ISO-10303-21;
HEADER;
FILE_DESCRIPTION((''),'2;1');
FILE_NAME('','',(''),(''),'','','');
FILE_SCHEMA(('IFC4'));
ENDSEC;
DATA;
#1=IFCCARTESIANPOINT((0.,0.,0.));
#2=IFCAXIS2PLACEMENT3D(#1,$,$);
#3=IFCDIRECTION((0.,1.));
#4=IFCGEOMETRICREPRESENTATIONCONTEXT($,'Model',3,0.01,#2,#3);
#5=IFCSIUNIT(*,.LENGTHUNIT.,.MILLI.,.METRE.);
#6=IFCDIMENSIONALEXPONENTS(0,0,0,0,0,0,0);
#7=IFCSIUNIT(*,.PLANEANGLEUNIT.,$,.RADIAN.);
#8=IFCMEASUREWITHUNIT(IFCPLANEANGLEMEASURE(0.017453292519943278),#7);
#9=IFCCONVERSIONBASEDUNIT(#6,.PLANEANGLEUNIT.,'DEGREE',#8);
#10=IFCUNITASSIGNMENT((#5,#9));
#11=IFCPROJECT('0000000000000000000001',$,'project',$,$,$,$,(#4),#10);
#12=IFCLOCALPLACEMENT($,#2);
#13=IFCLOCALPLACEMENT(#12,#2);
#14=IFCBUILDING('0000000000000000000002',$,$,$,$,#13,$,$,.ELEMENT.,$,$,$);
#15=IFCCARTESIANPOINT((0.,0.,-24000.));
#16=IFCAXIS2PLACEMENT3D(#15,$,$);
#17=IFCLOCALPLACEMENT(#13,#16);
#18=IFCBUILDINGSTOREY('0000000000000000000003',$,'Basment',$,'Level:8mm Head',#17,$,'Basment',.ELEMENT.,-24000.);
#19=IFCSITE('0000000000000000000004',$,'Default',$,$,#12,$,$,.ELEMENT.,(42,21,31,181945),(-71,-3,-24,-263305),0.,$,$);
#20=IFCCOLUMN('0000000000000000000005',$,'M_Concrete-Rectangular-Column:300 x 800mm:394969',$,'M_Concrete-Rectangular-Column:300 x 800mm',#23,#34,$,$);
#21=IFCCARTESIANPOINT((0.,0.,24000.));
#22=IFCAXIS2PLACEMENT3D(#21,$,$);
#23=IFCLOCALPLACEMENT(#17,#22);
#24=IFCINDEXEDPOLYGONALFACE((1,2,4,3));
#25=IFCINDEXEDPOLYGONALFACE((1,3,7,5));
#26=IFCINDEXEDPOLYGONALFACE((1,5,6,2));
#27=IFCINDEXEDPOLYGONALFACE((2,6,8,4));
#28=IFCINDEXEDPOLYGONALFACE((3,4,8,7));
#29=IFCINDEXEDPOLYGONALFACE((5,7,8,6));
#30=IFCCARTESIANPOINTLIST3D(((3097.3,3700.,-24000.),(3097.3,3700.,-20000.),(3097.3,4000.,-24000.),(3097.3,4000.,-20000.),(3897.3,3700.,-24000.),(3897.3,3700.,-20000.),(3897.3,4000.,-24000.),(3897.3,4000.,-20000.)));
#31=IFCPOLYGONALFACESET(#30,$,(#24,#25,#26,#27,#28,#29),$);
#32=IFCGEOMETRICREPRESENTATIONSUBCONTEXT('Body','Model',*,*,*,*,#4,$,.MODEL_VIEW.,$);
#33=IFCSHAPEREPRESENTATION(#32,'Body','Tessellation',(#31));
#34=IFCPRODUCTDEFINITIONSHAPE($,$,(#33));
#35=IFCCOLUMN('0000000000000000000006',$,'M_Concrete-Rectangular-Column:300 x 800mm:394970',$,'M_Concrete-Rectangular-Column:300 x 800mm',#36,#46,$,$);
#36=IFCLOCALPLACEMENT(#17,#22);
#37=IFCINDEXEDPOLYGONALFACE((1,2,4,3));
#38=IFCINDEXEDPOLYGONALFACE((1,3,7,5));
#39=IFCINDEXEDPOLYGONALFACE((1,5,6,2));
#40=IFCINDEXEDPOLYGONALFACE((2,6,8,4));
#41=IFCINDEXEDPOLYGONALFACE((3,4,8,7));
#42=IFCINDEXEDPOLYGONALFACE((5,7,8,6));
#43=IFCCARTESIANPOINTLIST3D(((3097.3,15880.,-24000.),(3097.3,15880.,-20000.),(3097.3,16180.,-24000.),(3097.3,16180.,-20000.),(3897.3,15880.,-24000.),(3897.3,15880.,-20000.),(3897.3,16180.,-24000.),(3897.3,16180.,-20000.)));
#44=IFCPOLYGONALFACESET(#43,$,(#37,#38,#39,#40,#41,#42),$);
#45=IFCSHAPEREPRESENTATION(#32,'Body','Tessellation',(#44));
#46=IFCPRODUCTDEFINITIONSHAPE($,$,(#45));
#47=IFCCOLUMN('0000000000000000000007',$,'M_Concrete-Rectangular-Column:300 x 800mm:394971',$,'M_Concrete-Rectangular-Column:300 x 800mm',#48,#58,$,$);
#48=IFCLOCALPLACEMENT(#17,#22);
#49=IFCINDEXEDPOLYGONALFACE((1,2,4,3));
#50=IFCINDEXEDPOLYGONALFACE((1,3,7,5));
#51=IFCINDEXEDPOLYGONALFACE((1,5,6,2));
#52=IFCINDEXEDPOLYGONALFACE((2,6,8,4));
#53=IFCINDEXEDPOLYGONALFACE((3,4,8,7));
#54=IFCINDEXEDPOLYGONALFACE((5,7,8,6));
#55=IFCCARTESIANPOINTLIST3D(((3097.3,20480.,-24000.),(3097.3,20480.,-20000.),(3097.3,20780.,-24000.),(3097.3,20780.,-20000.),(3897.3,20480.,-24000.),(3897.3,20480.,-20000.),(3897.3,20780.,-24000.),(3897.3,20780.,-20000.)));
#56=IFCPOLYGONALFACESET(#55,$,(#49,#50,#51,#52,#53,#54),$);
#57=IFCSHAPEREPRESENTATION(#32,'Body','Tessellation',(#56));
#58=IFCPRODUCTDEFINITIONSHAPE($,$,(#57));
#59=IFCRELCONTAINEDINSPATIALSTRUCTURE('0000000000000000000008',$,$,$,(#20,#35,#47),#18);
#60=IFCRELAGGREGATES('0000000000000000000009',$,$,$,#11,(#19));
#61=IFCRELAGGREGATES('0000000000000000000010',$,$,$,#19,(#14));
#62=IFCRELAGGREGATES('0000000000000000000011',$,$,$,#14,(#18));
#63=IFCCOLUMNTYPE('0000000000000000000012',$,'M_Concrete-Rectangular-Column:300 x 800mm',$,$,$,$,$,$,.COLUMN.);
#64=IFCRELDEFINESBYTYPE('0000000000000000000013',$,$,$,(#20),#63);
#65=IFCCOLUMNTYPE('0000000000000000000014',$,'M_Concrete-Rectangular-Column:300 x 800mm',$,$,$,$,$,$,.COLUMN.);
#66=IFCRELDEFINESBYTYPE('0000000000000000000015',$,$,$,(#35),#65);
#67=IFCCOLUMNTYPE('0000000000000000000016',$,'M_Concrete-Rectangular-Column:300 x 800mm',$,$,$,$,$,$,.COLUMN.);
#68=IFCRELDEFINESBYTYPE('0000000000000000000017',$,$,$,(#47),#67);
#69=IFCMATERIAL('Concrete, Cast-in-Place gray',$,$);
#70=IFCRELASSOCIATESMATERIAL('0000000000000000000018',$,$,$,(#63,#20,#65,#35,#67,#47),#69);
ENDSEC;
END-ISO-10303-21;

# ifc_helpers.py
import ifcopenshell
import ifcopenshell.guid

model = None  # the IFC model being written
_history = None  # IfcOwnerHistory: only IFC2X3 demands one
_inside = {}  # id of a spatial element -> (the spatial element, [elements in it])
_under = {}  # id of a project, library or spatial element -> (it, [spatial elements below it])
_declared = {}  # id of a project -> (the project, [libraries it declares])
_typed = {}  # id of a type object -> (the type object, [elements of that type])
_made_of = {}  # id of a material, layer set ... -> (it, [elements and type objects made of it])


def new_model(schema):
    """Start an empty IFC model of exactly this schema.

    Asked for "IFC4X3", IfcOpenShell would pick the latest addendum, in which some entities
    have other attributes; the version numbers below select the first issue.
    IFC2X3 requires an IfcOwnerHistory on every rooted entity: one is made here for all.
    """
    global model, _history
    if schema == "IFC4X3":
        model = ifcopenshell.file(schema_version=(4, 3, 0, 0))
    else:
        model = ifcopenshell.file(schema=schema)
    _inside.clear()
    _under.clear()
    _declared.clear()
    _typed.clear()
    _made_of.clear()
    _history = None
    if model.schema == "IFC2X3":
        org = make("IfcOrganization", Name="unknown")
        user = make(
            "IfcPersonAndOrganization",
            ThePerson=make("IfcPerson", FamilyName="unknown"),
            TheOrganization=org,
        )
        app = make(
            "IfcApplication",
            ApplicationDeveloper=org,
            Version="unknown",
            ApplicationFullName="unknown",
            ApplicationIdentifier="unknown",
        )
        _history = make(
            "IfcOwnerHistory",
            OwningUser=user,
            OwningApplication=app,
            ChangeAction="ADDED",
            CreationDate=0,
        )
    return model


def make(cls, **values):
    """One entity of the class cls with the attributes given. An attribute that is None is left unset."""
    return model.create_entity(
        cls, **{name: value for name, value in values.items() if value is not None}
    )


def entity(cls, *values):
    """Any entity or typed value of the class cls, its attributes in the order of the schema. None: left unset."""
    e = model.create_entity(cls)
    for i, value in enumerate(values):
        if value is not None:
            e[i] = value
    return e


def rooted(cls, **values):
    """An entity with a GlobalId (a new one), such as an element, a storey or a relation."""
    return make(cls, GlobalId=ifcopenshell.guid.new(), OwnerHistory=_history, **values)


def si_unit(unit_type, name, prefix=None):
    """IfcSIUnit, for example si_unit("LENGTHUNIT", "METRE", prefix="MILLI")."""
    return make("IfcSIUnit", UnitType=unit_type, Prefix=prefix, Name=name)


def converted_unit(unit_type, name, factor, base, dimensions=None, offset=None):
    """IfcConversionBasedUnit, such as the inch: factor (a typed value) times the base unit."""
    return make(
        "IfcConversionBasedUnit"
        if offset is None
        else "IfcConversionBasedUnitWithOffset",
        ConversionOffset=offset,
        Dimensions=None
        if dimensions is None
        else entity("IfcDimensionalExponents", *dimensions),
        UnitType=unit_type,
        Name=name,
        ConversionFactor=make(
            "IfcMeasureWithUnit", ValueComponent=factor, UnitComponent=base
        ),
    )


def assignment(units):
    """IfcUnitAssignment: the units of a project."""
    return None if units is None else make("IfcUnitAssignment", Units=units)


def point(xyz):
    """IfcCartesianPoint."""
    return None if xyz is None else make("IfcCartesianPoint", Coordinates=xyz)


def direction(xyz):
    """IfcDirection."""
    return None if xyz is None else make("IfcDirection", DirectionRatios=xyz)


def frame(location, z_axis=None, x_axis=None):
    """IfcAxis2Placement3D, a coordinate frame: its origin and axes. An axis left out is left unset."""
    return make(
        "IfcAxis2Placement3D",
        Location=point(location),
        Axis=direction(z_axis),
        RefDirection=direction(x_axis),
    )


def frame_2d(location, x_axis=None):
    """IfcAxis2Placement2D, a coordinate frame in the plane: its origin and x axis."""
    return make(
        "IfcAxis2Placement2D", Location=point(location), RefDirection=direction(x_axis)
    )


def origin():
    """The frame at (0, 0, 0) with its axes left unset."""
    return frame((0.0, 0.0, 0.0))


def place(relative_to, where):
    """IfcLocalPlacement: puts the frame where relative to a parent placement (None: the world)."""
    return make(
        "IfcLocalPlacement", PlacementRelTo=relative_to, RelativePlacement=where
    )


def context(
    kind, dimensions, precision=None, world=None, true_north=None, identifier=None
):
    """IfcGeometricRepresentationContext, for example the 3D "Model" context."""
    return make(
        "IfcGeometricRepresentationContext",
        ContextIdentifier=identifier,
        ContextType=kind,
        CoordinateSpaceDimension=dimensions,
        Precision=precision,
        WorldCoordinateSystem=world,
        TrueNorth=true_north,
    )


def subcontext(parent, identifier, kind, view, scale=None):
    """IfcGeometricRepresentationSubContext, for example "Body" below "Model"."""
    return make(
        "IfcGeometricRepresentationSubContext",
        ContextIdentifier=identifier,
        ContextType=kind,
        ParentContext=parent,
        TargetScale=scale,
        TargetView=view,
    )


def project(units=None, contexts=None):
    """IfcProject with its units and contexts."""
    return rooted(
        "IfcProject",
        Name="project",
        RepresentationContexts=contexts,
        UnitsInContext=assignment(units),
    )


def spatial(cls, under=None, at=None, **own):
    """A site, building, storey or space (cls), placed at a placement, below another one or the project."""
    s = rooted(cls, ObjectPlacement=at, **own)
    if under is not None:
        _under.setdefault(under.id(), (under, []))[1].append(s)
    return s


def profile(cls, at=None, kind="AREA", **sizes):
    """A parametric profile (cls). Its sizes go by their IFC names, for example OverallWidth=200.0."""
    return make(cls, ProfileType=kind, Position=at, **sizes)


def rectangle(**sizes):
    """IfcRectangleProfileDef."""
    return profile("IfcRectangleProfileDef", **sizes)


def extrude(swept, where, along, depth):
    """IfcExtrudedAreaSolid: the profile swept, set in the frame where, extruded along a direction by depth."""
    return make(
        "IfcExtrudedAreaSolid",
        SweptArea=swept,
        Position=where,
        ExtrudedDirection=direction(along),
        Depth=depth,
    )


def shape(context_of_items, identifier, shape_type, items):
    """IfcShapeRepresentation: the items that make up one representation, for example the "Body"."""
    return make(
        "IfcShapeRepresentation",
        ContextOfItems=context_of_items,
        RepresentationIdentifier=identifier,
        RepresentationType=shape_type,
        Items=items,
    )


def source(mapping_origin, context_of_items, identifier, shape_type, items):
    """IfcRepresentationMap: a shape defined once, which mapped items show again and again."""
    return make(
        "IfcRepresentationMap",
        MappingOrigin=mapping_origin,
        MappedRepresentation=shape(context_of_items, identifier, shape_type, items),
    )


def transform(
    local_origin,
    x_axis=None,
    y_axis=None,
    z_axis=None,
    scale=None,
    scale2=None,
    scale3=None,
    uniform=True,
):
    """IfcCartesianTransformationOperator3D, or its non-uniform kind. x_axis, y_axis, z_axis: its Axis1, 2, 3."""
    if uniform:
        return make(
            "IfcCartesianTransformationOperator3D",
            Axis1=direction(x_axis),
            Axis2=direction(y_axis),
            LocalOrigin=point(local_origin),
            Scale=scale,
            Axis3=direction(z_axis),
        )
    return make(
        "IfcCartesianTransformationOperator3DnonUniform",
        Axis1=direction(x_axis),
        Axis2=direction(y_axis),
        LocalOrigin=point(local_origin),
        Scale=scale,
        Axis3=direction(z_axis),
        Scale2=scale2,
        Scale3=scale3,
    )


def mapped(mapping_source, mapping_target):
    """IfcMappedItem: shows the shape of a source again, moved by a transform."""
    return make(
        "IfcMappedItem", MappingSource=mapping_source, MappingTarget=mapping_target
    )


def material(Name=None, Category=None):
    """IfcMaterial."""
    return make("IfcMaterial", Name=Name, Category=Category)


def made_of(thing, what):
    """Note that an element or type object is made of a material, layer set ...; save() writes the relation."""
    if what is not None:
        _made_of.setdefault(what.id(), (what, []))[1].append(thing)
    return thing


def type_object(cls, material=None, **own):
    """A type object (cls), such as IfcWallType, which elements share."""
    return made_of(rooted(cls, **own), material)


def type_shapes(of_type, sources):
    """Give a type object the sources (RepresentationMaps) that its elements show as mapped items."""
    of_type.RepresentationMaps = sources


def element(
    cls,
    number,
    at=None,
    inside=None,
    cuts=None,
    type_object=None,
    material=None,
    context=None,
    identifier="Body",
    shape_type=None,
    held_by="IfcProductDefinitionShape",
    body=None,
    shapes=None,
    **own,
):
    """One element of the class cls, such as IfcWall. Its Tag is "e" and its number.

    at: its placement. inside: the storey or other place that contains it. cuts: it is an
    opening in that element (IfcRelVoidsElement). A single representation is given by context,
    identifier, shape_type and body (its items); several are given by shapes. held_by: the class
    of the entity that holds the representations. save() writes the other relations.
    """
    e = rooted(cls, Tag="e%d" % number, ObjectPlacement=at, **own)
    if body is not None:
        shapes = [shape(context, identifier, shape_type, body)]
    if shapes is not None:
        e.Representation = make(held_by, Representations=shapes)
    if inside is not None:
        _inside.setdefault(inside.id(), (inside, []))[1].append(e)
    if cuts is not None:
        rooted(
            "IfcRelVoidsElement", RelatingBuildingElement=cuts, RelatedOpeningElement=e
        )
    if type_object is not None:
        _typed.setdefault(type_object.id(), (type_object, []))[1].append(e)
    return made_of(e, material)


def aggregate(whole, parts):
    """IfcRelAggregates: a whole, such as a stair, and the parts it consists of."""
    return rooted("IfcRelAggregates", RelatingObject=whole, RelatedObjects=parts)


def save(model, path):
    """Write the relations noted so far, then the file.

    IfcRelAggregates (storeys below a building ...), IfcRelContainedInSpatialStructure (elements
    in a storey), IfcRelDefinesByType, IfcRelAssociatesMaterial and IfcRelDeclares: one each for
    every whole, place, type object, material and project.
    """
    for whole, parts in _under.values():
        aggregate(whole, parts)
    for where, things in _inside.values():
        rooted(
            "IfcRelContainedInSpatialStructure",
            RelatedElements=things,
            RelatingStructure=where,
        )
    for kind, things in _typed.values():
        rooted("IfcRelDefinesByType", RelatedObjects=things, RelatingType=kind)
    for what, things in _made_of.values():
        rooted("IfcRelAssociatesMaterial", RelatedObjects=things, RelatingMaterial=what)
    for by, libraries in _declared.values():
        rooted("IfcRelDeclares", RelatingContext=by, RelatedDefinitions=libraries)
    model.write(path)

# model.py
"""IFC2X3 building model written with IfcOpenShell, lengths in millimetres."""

from ifc_helpers import new_model, entity, si_unit, converted_unit, direction, frame, frame_2d, origin, place, context, subcontext, project, spatial, rectangle, extrude, source, transform, mapped, material, type_object, type_shapes, element, save


model = new_model("IFC2X3")

# Units and contexts
model_context = context("Model", 3, precision=0.01, world=origin(), true_north=direction((0.0, 1.0)))
body_context = subcontext(model_context, "Body", "Model", "MODEL_VIEW")
ifc_project = project(units=[si_unit("LENGTHUNIT", "METRE", prefix="MILLI"), converted_unit("PLANEANGLEUNIT", "DEGREE", entity("IfcPlaneAngleMeasure", 0.017453292519943278), si_unit("PLANEANGLEUNIT", "RADIAN"), dimensions=[0, 0, 0, 0, 0, 0, 0])], contexts=[model_context])

# Site, building, storey
site_placement = place(None, origin())
site = spatial("IfcSite", under=ifc_project, at=site_placement, Name="Default", CompositionType="ELEMENT", RefLatitude=(42, 21, 31, 181945), RefLongitude=(-71, -3, -24, -263305), RefElevation=0.0)
building_placement = place(site_placement, origin())
building = spatial("IfcBuilding", under=site, at=building_placement, CompositionType="ELEMENT")
storey_placement = place(building_placement, frame((0.0, 0.0, -24000.0)))
storey = spatial("IfcBuildingStorey", under=building, at=storey_placement, Name="Basment", ObjectType="Level:8mm Head", LongName="Basment", CompositionType="ELEMENT", Elevation=-24000.0)

# Columns
ifc_material = material(Name="Concrete, Cast-in-Place gray")
column_type_1 = type_object("IfcColumnType", Name="M_Concrete-Rectangular-Column:300 x 800mm", PredefinedType="COLUMN", material=ifc_material)
shared_shape_1 = source(origin(), body_context, "Body", "SweptSolid", [
    extrude(rectangle(XDim=300.0, YDim=800.0, at=frame_2d((0.0, 0.0), x_axis=(1.0, 0.0))), frame((3497.3, 3850.0, -24000.0), z_axis=(0.0, 0.0, 1.0), x_axis=(0.0, 1.0, 0.0)), (0.0, 0.0, 1.0), 4000.0),
])
type_shapes(column_type_1, [shared_shape_1])
column_1_placement = place(storey_placement, frame((0.0, 0.0, 24000.0)))
element("IfcColumn", 1, at=column_1_placement, inside=storey, type_object=column_type_1, material=ifc_material, Name="M_Concrete-Rectangular-Column:300 x 800mm:394969", ObjectType="M_Concrete-Rectangular-Column:300 x 800mm", context=body_context, shape_type="MappedRepresentation", body=[
    mapped(shared_shape_1, transform((0.0, 0.0, 0.0), scale=1.0)),
])
column_type_2 = type_object("IfcColumnType", Name="M_Concrete-Rectangular-Column:300 x 800mm", PredefinedType="COLUMN", material=ifc_material)
shared_shape_2 = source(origin(), body_context, "Body", "SweptSolid", [
    extrude(rectangle(XDim=300.0, YDim=800.0, at=frame_2d((0.0, 0.0), x_axis=(1.0, 0.0))), frame((3497.3, 16030.0, -24000.0), z_axis=(0.0, 0.0, 1.0), x_axis=(0.0, 1.0, 0.0)), (0.0, 0.0, 1.0), 4000.0),
])
type_shapes(column_type_2, [shared_shape_2])
column_2_placement = place(storey_placement, frame((0.0, 0.0, 24000.0)))
element("IfcColumn", 2, at=column_2_placement, inside=storey, type_object=column_type_2, material=ifc_material, Name="M_Concrete-Rectangular-Column:300 x 800mm:394970", ObjectType="M_Concrete-Rectangular-Column:300 x 800mm", context=body_context, shape_type="MappedRepresentation", body=[
    mapped(shared_shape_2, transform((0.0, 0.0, 0.0), scale=1.0)),
])
column_type_3 = type_object("IfcColumnType", Name="M_Concrete-Rectangular-Column:300 x 800mm", PredefinedType="COLUMN", material=ifc_material)
shared_shape_3 = source(origin(), body_context, "Body", "SweptSolid", [
    extrude(rectangle(XDim=300.0, YDim=800.0, at=frame_2d((0.0, 0.0), x_axis=(1.0, 0.0))), frame((3497.3, 20630.0, -24000.0), z_axis=(0.0, 0.0, 1.0), x_axis=(0.0, 1.0, 0.0)), (0.0, 0.0, 1.0), 4000.0),
])
type_shapes(column_type_3, [shared_shape_3])
column_3_placement = place(storey_placement, frame((0.0, 0.0, 24000.0)))
element("IfcColumn", 3, at=column_3_placement, inside=storey, type_object=column_type_3, material=ifc_material, Name="M_Concrete-Rectangular-Column:300 x 800mm:394971", ObjectType="M_Concrete-Rectangular-Column:300 x 800mm", context=body_context, shape_type="MappedRepresentation", body=[
    mapped(shared_shape_3, transform((0.0, 0.0, 0.0), scale=1.0)),
])

save(model, "model.ifc")
